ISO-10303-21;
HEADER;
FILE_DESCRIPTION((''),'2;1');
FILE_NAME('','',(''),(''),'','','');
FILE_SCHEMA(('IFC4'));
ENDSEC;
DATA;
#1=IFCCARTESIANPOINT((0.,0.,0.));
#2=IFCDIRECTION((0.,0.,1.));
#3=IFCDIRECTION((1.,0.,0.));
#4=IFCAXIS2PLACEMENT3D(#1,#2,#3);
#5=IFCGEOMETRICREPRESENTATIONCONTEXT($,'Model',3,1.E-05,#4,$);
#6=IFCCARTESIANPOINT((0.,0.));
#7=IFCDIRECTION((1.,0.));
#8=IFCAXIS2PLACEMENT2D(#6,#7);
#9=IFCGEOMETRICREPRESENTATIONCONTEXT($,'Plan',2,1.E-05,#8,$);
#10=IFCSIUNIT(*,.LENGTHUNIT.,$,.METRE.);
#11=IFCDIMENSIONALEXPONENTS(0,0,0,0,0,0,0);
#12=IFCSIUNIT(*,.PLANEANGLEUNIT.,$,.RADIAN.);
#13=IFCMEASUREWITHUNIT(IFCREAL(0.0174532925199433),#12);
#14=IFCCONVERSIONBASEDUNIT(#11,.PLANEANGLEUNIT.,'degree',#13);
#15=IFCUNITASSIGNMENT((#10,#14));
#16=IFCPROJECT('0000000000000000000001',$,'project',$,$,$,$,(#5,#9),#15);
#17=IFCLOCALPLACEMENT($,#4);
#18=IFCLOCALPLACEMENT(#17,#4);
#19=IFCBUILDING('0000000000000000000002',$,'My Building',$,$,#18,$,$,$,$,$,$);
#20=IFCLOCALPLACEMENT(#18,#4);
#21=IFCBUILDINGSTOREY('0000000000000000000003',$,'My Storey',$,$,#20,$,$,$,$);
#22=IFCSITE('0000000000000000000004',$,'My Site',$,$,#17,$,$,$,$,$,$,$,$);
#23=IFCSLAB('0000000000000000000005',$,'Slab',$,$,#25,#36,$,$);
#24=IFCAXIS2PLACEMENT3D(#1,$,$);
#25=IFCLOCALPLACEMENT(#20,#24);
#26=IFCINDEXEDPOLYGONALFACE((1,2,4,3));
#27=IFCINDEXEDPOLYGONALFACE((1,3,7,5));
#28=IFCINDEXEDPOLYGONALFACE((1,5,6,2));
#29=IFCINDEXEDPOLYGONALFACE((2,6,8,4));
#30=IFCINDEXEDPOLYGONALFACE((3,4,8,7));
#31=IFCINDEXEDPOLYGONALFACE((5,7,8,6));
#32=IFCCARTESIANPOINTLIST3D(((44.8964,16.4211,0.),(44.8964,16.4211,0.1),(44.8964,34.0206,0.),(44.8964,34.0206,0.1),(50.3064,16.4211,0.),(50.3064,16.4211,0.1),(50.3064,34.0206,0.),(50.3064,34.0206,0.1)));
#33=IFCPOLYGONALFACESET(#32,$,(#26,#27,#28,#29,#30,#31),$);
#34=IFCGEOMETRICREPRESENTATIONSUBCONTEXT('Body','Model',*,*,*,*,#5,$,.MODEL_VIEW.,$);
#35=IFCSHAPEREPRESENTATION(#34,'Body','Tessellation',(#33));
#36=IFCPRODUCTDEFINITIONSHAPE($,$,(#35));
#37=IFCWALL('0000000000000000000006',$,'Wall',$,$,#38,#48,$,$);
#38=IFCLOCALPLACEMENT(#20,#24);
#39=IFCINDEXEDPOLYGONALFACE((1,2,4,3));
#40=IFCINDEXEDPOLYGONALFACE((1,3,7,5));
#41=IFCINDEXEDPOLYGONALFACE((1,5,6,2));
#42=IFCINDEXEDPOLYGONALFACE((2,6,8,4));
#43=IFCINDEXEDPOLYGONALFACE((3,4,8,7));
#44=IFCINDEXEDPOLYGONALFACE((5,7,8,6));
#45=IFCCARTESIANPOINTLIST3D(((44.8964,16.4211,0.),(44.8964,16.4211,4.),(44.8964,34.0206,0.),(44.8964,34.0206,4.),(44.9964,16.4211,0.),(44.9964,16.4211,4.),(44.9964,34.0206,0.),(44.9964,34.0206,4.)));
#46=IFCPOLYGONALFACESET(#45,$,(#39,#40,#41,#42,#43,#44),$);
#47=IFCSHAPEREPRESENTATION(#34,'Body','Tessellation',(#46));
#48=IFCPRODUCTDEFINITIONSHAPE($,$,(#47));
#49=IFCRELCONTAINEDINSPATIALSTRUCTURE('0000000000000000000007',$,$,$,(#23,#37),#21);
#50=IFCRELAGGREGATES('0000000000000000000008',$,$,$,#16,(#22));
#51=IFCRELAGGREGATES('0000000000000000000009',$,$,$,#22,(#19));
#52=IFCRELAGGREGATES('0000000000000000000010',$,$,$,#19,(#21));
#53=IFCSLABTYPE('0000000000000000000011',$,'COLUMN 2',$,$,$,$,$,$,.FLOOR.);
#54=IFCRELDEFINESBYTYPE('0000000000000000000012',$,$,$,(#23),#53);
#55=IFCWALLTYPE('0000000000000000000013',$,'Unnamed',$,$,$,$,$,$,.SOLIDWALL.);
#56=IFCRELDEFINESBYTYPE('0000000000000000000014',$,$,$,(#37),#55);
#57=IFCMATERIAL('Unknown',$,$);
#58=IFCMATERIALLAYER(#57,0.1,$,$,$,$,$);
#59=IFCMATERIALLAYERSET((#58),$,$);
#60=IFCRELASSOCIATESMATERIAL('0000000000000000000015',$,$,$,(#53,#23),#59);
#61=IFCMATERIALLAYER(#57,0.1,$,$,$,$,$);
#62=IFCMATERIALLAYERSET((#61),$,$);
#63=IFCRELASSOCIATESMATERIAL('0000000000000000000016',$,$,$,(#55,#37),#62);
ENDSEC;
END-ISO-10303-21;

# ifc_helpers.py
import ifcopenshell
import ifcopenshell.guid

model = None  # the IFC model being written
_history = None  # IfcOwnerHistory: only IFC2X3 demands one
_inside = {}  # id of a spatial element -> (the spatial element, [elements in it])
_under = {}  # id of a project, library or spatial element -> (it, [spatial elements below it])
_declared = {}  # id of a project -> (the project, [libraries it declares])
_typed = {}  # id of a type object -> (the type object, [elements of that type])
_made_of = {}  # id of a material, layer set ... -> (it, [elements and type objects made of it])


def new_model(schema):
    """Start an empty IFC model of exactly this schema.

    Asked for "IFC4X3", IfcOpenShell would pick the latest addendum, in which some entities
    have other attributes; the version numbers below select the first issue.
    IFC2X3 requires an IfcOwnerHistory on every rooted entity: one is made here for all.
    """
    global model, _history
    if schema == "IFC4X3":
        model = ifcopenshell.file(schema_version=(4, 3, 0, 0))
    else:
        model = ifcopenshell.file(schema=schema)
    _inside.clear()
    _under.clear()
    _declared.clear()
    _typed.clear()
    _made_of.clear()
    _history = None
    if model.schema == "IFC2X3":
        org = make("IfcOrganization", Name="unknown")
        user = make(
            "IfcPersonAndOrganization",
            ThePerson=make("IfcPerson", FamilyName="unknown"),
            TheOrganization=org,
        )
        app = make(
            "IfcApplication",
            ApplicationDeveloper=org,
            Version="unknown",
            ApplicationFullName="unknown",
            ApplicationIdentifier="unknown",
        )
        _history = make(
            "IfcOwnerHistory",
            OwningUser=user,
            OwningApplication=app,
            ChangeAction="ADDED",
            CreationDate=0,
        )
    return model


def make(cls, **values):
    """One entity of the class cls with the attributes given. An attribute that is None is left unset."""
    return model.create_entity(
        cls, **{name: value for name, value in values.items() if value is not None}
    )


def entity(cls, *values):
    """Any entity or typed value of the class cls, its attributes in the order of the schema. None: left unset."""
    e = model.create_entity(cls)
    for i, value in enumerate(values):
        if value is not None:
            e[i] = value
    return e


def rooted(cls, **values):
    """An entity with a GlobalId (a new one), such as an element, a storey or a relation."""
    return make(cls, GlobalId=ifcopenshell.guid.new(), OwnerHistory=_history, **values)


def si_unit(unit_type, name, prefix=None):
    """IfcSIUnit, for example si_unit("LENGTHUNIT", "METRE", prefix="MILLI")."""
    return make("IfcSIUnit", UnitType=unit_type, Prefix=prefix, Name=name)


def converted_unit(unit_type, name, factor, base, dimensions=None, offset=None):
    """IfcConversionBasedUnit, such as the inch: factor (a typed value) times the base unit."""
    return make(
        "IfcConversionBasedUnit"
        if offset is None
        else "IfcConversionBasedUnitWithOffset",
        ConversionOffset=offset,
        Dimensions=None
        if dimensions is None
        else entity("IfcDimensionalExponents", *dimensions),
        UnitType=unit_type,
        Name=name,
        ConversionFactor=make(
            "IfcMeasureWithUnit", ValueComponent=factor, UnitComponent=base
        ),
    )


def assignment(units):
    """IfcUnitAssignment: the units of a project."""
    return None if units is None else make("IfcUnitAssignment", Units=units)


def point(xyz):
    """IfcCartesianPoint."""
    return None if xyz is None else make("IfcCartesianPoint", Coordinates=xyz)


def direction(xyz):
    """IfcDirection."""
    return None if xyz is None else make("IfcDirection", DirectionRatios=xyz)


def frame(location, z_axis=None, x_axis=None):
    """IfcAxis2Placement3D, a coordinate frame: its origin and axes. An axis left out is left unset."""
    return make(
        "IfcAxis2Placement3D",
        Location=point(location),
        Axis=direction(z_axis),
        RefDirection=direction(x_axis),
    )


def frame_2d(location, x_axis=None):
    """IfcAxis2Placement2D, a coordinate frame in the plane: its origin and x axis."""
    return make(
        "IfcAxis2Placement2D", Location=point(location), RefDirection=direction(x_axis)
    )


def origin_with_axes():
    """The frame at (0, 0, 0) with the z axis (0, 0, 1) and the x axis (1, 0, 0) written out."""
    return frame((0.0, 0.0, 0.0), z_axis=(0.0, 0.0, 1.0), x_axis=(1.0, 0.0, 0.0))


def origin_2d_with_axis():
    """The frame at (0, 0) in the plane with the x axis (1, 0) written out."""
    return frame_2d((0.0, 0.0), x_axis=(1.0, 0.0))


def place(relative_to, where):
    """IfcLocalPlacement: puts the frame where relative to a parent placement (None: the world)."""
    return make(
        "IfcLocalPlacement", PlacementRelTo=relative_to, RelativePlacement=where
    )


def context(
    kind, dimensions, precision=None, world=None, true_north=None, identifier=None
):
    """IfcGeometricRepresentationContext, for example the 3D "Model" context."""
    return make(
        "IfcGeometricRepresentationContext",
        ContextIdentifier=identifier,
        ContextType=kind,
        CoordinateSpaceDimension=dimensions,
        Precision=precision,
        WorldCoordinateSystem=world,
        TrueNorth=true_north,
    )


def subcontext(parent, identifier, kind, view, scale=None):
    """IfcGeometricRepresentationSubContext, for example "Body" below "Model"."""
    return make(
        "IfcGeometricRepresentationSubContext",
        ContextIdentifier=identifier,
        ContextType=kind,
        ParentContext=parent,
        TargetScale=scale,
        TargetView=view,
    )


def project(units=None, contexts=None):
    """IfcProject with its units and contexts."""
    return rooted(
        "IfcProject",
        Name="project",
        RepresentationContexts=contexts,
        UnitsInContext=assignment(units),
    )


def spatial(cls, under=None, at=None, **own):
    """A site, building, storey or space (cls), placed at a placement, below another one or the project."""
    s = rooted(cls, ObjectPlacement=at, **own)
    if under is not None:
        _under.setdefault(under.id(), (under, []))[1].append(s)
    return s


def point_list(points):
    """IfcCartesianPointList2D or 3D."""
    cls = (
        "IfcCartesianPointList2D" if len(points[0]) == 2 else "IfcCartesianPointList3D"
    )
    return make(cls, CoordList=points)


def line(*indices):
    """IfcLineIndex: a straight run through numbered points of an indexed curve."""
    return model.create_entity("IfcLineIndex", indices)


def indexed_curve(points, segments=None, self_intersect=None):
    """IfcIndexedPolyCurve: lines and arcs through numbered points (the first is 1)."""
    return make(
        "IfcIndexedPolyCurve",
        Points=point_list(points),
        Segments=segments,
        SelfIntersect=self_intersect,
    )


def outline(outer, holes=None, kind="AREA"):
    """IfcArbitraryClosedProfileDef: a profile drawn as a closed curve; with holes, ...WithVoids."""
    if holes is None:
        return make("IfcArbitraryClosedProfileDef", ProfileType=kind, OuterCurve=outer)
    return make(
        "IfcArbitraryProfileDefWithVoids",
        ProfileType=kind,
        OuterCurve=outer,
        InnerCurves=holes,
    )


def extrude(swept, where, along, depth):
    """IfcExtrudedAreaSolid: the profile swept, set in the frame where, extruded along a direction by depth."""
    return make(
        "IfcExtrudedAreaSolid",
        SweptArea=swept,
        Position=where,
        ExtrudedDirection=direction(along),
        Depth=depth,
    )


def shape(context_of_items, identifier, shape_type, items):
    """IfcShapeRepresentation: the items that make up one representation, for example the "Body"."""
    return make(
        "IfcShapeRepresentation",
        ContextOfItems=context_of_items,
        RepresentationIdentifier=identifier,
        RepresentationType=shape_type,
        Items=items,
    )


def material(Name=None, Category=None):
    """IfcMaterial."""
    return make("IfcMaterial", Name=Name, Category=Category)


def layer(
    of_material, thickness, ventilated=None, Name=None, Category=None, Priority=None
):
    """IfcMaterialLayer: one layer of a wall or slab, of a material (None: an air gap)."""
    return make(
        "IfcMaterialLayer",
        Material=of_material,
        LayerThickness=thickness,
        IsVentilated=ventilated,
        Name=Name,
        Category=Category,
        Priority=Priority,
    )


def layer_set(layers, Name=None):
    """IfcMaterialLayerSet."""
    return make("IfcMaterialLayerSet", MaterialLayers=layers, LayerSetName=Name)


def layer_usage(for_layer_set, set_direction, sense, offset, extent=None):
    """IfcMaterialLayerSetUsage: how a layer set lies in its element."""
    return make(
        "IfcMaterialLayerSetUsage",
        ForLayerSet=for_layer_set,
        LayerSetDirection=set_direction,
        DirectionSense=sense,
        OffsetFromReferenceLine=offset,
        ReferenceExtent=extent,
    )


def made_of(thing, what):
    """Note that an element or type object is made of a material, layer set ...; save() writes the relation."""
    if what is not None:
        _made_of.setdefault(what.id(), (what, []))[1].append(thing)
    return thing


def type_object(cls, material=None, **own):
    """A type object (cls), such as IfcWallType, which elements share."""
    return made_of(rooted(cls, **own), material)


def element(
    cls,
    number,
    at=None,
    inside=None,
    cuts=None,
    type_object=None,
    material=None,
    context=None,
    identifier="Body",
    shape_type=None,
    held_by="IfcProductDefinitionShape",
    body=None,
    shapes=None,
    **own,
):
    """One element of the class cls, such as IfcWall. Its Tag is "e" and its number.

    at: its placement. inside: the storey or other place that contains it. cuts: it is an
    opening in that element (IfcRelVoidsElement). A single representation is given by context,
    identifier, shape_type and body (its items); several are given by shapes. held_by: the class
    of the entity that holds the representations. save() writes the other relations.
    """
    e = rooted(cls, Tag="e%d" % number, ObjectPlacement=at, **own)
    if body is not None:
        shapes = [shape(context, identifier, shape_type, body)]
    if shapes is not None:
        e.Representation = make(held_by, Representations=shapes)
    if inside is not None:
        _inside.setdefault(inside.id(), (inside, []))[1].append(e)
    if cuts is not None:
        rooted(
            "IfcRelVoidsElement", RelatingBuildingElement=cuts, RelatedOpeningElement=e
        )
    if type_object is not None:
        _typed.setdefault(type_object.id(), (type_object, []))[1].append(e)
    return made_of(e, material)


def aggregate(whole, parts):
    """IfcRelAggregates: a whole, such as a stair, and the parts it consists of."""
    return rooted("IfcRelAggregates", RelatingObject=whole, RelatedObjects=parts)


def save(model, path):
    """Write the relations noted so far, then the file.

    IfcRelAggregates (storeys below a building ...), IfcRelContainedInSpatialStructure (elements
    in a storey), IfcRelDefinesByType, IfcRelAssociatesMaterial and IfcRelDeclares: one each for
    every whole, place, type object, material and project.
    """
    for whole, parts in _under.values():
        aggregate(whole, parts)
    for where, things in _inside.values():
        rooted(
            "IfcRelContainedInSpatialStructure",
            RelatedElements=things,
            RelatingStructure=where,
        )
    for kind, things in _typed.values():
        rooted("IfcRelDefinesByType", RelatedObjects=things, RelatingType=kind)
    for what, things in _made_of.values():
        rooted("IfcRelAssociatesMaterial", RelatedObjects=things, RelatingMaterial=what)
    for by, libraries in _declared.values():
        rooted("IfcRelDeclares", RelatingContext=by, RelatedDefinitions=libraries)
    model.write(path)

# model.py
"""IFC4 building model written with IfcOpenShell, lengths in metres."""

from ifc_helpers import new_model, entity, si_unit, converted_unit, frame, origin_with_axes, origin_2d_with_axis, place, context, subcontext, project, spatial, line, indexed_curve, outline, extrude, material, layer, layer_set, layer_usage, type_object, element, save


model = new_model("IFC4")

# Units and contexts
model_context = context("Model", 3, precision=1e-05, world=origin_with_axes())
plan_context = context("Plan", 2, precision=1e-05, world=origin_2d_with_axis())
body_context = subcontext(model_context, "Body", "Model", "MODEL_VIEW")
ifc_project = project(units=[si_unit("LENGTHUNIT", "METRE"), converted_unit("PLANEANGLEUNIT", "degree", entity("IfcReal", 0.0174532925199433), si_unit("PLANEANGLEUNIT", "RADIAN"), dimensions=[0, 0, 0, 0, 0, 0, 0])], contexts=[model_context, plan_context])

# Site, building, storey
site_placement = place(None, origin_with_axes())
site = spatial("IfcSite", under=ifc_project, at=site_placement, Name="My Site")
building_placement = place(site_placement, origin_with_axes())
building = spatial("IfcBuilding", under=site, at=building_placement, Name="My Building")
storey_placement = place(building_placement, origin_with_axes())
storey = spatial("IfcBuildingStorey", under=building, at=storey_placement, Name="My Storey")

# Shared definitions
ifc_material = material(Name="Unknown")

# Slab
ifc_layer_1 = layer(ifc_material, 0.1)
ifc_layer_set_1 = layer_set([ifc_layer_1])
slab_type = type_object("IfcSlabType", Name="COLUMN 2", PredefinedType="FLOOR", material=ifc_layer_set_1)
ifc_layer_usage_1 = layer_usage(ifc_layer_set_1, "AXIS3", "POSITIVE", -0.1)
slab_1_placement = place(storey_placement, frame((50.3064, 16.4211, 0.1), z_axis=(0.0, 0.0, 1.0), x_axis=(1.0, 0.0, 0.0)))
element("IfcSlab", 1, at=slab_1_placement, inside=storey, type_object=slab_type, material=ifc_layer_usage_1, Name="Slab", context=body_context, shape_type="SweptSolid", body=[
    extrude(outline(indexed_curve([(0.0, 0.0), (-5.4099, 0.0), (-5.4099, 17.5994), (0.0, 17.5994), (0.0, 0.0)])), frame((0.0, 0.0, -0.1), z_axis=(0.0, 0.0, 1.0), x_axis=(1.0, 0.0, 0.0)), (0.0, 0.0, 1.0), 0.1),
])

# Wall
ifc_layer_2 = layer(ifc_material, 0.1)
ifc_layer_set_2 = layer_set([ifc_layer_2])
ifc_layer_usage_2 = layer_usage(ifc_layer_set_2, "AXIS2", "POSITIVE", 0.0)
wall_type = type_object("IfcWallType", Name="Unnamed", PredefinedType="SOLIDWALL", material=ifc_layer_set_2)
wall_placement = place(storey_placement, frame((44.8964, 34.0206, 0.0), z_axis=(0.0, 0.0, 1.0), x_axis=(0.0, -1.0, 0.0)))
element("IfcWall", 2, at=wall_placement, inside=storey, type_object=wall_type, material=ifc_layer_usage_2, Name="Wall", context=body_context, shape_type="SweptSolid", body=[
    extrude(outline(indexed_curve([(0.0, 0.0), (0.0, 0.1), (17.5994, 0.1), (17.5994, 0.0)], segments=[line(1, 2, 3, 4, 1)])), origin_with_axes(), (0.0, 0.0, 1.0), 4.0),
])

save(model, "model.ifc")
